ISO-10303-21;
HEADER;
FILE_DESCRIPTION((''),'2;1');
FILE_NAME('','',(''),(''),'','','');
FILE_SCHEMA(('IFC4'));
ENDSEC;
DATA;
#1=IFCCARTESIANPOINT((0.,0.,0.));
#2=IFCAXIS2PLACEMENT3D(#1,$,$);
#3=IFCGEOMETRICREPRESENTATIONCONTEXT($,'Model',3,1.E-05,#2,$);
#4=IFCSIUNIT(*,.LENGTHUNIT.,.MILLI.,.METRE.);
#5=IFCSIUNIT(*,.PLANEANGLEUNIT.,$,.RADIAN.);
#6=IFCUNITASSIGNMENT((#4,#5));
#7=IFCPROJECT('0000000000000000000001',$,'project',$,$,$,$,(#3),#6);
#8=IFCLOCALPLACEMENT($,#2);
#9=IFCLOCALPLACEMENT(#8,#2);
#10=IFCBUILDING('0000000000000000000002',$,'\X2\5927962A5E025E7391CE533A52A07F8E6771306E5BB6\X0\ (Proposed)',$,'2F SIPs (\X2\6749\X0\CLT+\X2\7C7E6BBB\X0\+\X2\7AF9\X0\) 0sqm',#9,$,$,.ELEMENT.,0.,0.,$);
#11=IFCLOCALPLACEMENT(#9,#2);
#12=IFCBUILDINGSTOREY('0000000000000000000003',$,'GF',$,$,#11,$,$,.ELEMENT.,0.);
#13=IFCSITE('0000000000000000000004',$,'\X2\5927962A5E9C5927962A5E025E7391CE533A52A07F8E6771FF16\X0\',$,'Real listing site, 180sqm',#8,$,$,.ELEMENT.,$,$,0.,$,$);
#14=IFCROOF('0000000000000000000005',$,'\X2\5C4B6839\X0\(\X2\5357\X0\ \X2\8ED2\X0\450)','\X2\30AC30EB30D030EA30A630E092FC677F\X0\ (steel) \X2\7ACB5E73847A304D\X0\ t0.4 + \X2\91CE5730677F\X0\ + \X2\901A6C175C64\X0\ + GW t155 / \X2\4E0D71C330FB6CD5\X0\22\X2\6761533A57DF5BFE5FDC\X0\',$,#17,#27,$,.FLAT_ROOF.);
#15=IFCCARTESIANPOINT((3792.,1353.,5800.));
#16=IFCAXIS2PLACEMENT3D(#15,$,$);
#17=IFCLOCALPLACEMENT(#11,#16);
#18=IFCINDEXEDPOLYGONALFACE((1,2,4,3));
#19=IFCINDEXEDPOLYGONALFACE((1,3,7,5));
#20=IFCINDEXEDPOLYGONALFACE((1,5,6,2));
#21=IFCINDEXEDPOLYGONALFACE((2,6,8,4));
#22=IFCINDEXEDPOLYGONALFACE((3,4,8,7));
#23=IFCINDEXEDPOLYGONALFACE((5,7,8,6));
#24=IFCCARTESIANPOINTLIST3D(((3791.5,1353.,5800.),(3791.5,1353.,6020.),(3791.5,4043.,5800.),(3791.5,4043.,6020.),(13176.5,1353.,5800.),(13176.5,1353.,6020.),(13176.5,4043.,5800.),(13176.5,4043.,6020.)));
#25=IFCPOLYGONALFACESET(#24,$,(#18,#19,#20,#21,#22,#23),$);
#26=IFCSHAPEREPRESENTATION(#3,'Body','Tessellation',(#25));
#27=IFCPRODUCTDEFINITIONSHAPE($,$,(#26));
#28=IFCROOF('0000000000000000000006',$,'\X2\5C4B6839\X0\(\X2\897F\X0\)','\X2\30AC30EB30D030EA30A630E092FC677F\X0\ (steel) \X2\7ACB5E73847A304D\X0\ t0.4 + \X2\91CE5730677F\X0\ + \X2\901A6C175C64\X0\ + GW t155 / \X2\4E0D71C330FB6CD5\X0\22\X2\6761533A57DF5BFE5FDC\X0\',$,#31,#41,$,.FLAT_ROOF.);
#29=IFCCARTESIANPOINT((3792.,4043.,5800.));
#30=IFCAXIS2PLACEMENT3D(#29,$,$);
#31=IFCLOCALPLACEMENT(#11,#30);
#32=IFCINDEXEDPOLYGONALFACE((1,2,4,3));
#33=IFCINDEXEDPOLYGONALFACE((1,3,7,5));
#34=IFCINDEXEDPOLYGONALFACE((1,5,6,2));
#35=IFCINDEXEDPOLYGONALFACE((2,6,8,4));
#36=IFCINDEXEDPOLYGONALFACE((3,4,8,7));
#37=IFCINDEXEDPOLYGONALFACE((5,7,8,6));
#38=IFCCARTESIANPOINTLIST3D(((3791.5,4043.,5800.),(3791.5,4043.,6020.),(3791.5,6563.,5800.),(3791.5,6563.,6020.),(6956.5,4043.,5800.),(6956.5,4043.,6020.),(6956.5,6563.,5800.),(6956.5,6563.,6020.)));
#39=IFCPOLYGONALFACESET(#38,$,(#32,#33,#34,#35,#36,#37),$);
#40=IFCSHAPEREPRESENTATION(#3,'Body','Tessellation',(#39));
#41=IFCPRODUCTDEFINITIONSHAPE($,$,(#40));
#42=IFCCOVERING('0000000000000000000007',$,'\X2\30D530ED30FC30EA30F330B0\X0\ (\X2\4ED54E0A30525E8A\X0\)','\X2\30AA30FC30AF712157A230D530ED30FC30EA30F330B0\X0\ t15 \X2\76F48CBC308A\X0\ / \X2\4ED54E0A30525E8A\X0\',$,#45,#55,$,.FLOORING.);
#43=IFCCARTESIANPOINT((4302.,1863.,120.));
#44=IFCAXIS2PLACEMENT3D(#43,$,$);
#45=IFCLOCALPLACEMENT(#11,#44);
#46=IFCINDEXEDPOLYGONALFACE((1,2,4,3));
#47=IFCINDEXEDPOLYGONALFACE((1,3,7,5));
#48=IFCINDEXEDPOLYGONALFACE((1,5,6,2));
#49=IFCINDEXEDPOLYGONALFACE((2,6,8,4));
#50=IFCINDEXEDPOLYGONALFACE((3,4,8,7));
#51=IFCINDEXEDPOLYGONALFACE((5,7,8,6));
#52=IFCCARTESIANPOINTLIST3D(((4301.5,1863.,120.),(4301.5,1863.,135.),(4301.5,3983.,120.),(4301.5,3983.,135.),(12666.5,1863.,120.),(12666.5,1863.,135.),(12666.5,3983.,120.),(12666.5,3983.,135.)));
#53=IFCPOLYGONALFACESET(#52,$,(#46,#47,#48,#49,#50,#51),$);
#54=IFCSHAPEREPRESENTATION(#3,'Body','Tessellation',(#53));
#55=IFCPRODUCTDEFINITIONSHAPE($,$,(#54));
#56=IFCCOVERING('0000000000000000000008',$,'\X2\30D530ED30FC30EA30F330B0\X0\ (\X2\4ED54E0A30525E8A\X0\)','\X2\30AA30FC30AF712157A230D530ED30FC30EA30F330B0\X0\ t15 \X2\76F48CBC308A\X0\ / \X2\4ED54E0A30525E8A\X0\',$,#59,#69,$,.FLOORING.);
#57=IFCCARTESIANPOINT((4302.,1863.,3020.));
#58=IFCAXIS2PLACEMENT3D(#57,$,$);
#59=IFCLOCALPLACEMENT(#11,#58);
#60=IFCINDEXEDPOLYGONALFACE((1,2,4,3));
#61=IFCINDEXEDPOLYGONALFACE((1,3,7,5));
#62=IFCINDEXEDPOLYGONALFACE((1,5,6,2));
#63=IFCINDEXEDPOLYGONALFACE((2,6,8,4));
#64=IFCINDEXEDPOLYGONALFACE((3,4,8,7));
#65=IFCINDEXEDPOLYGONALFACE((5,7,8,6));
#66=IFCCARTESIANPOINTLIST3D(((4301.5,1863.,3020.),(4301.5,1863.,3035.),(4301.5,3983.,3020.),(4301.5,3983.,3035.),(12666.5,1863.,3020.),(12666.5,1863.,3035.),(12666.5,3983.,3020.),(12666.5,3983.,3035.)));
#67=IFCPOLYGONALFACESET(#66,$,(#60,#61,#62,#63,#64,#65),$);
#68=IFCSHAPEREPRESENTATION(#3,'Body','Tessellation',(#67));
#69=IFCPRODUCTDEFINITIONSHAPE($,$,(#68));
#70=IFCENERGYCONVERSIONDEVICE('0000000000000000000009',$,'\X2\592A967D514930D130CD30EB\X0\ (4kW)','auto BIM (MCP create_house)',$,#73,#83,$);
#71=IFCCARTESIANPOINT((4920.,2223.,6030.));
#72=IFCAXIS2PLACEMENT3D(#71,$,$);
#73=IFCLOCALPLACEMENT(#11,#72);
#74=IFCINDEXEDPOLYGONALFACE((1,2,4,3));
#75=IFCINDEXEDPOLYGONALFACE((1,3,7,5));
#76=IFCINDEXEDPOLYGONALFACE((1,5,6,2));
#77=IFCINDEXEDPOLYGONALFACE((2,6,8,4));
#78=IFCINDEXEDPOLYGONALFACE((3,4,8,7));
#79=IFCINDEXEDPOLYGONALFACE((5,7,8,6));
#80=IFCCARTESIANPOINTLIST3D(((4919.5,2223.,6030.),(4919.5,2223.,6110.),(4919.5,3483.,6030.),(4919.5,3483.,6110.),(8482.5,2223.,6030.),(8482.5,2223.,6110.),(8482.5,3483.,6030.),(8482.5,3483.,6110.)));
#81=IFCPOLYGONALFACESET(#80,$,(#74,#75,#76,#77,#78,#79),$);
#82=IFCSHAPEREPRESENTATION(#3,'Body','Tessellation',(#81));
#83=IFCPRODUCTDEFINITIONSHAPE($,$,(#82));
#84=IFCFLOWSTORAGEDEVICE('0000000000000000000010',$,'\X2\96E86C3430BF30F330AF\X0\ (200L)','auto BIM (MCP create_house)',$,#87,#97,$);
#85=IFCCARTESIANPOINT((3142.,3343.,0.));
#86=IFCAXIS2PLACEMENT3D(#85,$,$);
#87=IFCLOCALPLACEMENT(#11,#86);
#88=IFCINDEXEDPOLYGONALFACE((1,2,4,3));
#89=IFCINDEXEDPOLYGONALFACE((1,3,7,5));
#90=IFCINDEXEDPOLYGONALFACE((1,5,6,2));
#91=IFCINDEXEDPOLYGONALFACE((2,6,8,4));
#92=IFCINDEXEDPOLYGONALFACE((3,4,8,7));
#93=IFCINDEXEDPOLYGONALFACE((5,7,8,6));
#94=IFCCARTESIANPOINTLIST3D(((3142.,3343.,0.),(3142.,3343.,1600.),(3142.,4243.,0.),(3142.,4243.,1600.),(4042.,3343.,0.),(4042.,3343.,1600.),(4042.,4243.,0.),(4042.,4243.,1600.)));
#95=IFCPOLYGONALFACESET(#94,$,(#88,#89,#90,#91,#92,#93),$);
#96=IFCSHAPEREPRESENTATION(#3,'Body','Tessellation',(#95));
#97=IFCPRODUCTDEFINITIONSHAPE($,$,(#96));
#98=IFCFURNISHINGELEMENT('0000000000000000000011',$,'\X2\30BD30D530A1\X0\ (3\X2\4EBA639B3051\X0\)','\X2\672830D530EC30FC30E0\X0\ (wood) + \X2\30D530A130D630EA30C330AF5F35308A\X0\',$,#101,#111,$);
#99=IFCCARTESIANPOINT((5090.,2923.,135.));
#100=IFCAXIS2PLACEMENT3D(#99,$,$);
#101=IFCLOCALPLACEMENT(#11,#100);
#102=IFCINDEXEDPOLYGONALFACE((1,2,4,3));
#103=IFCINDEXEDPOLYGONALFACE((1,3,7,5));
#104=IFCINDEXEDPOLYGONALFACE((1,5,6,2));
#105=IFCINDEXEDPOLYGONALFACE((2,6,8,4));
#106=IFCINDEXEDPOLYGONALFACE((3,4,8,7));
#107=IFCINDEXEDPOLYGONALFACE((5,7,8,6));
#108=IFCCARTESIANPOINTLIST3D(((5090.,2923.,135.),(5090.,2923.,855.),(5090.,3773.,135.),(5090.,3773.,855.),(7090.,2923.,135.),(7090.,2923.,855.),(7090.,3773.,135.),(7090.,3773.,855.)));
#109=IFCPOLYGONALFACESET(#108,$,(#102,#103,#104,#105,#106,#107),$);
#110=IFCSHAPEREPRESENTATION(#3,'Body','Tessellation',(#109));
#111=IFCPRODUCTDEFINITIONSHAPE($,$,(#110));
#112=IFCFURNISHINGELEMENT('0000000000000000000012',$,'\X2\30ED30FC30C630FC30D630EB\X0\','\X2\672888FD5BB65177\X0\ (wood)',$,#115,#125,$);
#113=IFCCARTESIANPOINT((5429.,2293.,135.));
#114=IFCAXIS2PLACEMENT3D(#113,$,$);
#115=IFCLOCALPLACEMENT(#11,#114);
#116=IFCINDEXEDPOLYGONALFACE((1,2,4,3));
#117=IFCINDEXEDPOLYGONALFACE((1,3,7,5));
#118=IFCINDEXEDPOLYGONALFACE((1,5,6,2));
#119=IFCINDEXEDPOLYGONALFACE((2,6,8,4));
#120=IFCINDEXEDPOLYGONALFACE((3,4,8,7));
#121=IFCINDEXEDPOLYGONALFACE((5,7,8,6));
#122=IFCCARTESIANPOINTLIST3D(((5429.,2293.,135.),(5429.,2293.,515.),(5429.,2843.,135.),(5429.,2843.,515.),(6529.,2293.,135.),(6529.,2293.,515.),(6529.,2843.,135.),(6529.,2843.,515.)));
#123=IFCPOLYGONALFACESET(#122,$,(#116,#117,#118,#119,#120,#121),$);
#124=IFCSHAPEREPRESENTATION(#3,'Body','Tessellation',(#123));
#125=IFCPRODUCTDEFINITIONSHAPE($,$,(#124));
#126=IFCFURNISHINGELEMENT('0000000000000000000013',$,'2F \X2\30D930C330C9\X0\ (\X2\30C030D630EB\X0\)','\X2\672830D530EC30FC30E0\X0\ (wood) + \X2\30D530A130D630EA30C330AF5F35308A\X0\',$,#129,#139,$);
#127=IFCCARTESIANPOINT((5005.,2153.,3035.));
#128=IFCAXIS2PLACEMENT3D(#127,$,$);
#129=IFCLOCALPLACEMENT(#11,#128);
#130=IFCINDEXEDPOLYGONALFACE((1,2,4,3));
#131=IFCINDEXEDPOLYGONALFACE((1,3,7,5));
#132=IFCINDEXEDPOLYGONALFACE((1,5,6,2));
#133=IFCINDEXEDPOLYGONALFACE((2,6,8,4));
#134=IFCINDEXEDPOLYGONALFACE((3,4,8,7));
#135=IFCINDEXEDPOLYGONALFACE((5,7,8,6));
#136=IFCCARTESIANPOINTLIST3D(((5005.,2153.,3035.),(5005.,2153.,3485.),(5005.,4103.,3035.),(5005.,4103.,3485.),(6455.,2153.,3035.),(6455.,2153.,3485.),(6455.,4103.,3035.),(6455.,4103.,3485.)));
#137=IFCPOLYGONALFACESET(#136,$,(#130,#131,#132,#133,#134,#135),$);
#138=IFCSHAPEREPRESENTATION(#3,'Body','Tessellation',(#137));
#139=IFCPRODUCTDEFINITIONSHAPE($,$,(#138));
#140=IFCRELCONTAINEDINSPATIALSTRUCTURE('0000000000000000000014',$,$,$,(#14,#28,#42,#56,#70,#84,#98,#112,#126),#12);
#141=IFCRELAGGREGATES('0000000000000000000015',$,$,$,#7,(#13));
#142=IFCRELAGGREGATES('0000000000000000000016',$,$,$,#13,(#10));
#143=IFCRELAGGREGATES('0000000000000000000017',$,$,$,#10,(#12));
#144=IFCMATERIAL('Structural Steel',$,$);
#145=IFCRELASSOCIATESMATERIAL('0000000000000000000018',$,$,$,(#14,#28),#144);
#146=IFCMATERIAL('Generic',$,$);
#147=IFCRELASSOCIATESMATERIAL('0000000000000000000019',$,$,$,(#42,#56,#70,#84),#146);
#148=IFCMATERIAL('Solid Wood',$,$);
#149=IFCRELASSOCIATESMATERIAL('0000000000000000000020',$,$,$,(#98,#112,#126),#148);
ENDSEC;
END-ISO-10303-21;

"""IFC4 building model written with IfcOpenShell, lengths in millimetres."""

from ifc_helpers import new_model, si_unit, frame, frame_2d, origin, place, context, project, spatial, rectangle, extrude, material, element, save


model = new_model("IFC4")

# Units and contexts
model_context = context("Model", 3, precision=1e-05, world=origin())
ifc_project = project(units=[si_unit("LENGTHUNIT", "METRE", prefix="MILLI"), si_unit("PLANEANGLEUNIT", "RADIAN")], contexts=[model_context])

# Site, building, storey
site_placement = place(None, origin())
site = spatial("IfcSite", under=ifc_project, at=site_placement, Name="大阪府大阪市平野区加美東６", ObjectType="Real listing site, 180sqm", CompositionType="ELEMENT", RefElevation=0.0)
building_placement = place(site_placement, origin())
building = spatial("IfcBuilding", under=site, at=building_placement, Name="大阪市平野区加美東の家 (Proposed)", ObjectType="2F SIPs (杉CLT+籾殻+竹) 0sqm", CompositionType="ELEMENT", ElevationOfRefHeight=0.0, ElevationOfTerrain=0.0)
storey_placement = place(building_placement, origin())
storey = spatial("IfcBuildingStorey", under=building, at=storey_placement, Name="GF", CompositionType="ELEMENT", Elevation=0.0)

# Shared definitions
ifc_material_1 = material(Name="Solid Wood")

# Roofs
ifc_material_2 = material(Name="Structural Steel")
roof_1_placement = place(storey_placement, frame((3792.0, 1353.0, 5800.0)))
element("IfcRoof", 1, at=roof_1_placement, inside=storey, material=ifc_material_2, Name="屋根(南 軒450)", Description="ガルバリウム鋼板 (steel) 立平葺き t0.4 + 野地板 + 通気層 + GW t155 / 不燃・法22条区域対応", PredefinedType="FLAT_ROOF", context=model_context, shape_type="SweptSolid", body=[
    extrude(rectangle(XDim=9385.0, YDim=2690.0, at=frame_2d((4692.0, 1345.0))), frame((3792.0, 1353.0, 5800.0)), (0.0, 0.0, 1.0), 220.0),
])
roof_2_placement = place(storey_placement, frame((3792.0, 4043.0, 5800.0)))
element("IfcRoof", 2, at=roof_2_placement, inside=storey, material=ifc_material_2, Name="屋根(西)", Description="ガルバリウム鋼板 (steel) 立平葺き t0.4 + 野地板 + 通気層 + GW t155 / 不燃・法22条区域対応", PredefinedType="FLAT_ROOF", context=model_context, shape_type="SweptSolid", body=[
    extrude(rectangle(XDim=3165.0, YDim=2520.0, at=frame_2d((1582.0, 1260.0))), frame((3792.0, 4043.0, 5800.0)), (0.0, 0.0, 1.0), 220.0),
])

# Coverings
ifc_material_3 = material(Name="Generic")
covering_1_placement = place(storey_placement, frame((4302.0, 1863.0, 120.0)))
element("IfcCovering", 3, at=covering_1_placement, inside=storey, material=ifc_material_3, Name="フローリング (仕上げ床)", Description="オーク無垢フローリング t15 直貼り / 仕上げ床", PredefinedType="FLOORING", context=model_context, shape_type="SweptSolid", body=[
    extrude(rectangle(XDim=8365.0, YDim=2120.0, at=frame_2d((4182.0, 1060.0))), frame((4302.0, 1863.0, 120.0)), (0.0, 0.0, 1.0), 15.0),
])
covering_2_placement = place(storey_placement, frame((4302.0, 1863.0, 3020.0)))
element("IfcCovering", 4, at=covering_2_placement, inside=storey, material=ifc_material_3, Name="フローリング (仕上げ床)", Description="オーク無垢フローリング t15 直貼り / 仕上げ床", PredefinedType="FLOORING", context=model_context, shape_type="SweptSolid", body=[
    extrude(rectangle(XDim=8365.0, YDim=2120.0, at=frame_2d((4182.0, 1060.0))), frame((4302.0, 1863.0, 3020.0)), (0.0, 0.0, 1.0), 15.0),
])

# Energy conversion device
energy_conversion_device_placement = place(storey_placement, frame((4920.0, 2223.0, 6030.0)))
element("IfcEnergyConversionDevice", 5, at=energy_conversion_device_placement, inside=storey, material=ifc_material_3, Name="太陽光パネル (4kW)", Description="auto BIM (MCP create_house)", context=model_context, shape_type="SweptSolid", body=[
    extrude(rectangle(XDim=3563.0, YDim=1260.0, at=frame_2d((1781.0, 630.0))), frame((4920.0, 2223.0, 6030.0)), (0.0, 0.0, 1.0), 80.0),
])

# Flow storage device
flow_storage_device_placement = place(storey_placement, frame((3142.0, 3343.0, 0.0)))
element("IfcFlowStorageDevice", 6, at=flow_storage_device_placement, inside=storey, material=ifc_material_3, Name="雨水タンク (200L)", Description="auto BIM (MCP create_house)", context=model_context, shape_type="SweptSolid", body=[
    extrude(rectangle(XDim=900.0, YDim=900.0, at=frame_2d((450.0, 450.0))), frame((3142.0, 3343.0, 0.0)), (0.0, 0.0, 1.0), 1600.0),
])

# Furnishing elements
furnishing_1_placement = place(storey_placement, frame((5090.0, 2923.0, 135.0)))
element("IfcFurnishingElement", 7, at=furnishing_1_placement, inside=storey, material=ifc_material_1, Name="ソファ (3人掛け)", Description="木フレーム (wood) + ファブリック張り", context=model_context, shape_type="SweptSolid", body=[
    extrude(rectangle(XDim=2000.0, YDim=850.0, at=frame_2d((1000.0, 425.0))), frame((5090.0, 2923.0, 135.0)), (0.0, 0.0, 1.0), 720.0),
])
furnishing_2_placement = place(storey_placement, frame((5429.0, 2293.0, 135.0)))
element("IfcFurnishingElement", 8, at=furnishing_2_placement, inside=storey, material=ifc_material_1, Name="ローテーブル", Description="木製家具 (wood)", context=model_context, shape_type="SweptSolid", body=[
    extrude(rectangle(XDim=1100.0, YDim=550.0, at=frame_2d((550.0, 275.0))), frame((5429.0, 2293.0, 135.0)), (0.0, 0.0, 1.0), 380.0),
])
furnishing_3_placement = place(storey_placement, frame((5005.0, 2153.0, 3035.0)))
element("IfcFurnishingElement", 9, at=furnishing_3_placement, inside=storey, material=ifc_material_1, Name="2F ベッド (ダブル)", Description="木フレーム (wood) + ファブリック張り", context=model_context, shape_type="SweptSolid", body=[
    extrude(rectangle(XDim=1450.0, YDim=1950.0, at=frame_2d((725.0, 975.0))), frame((5005.0, 2153.0, 3035.0)), (0.0, 0.0, 1.0), 450.0),
])

save(model, "model.ifc")
